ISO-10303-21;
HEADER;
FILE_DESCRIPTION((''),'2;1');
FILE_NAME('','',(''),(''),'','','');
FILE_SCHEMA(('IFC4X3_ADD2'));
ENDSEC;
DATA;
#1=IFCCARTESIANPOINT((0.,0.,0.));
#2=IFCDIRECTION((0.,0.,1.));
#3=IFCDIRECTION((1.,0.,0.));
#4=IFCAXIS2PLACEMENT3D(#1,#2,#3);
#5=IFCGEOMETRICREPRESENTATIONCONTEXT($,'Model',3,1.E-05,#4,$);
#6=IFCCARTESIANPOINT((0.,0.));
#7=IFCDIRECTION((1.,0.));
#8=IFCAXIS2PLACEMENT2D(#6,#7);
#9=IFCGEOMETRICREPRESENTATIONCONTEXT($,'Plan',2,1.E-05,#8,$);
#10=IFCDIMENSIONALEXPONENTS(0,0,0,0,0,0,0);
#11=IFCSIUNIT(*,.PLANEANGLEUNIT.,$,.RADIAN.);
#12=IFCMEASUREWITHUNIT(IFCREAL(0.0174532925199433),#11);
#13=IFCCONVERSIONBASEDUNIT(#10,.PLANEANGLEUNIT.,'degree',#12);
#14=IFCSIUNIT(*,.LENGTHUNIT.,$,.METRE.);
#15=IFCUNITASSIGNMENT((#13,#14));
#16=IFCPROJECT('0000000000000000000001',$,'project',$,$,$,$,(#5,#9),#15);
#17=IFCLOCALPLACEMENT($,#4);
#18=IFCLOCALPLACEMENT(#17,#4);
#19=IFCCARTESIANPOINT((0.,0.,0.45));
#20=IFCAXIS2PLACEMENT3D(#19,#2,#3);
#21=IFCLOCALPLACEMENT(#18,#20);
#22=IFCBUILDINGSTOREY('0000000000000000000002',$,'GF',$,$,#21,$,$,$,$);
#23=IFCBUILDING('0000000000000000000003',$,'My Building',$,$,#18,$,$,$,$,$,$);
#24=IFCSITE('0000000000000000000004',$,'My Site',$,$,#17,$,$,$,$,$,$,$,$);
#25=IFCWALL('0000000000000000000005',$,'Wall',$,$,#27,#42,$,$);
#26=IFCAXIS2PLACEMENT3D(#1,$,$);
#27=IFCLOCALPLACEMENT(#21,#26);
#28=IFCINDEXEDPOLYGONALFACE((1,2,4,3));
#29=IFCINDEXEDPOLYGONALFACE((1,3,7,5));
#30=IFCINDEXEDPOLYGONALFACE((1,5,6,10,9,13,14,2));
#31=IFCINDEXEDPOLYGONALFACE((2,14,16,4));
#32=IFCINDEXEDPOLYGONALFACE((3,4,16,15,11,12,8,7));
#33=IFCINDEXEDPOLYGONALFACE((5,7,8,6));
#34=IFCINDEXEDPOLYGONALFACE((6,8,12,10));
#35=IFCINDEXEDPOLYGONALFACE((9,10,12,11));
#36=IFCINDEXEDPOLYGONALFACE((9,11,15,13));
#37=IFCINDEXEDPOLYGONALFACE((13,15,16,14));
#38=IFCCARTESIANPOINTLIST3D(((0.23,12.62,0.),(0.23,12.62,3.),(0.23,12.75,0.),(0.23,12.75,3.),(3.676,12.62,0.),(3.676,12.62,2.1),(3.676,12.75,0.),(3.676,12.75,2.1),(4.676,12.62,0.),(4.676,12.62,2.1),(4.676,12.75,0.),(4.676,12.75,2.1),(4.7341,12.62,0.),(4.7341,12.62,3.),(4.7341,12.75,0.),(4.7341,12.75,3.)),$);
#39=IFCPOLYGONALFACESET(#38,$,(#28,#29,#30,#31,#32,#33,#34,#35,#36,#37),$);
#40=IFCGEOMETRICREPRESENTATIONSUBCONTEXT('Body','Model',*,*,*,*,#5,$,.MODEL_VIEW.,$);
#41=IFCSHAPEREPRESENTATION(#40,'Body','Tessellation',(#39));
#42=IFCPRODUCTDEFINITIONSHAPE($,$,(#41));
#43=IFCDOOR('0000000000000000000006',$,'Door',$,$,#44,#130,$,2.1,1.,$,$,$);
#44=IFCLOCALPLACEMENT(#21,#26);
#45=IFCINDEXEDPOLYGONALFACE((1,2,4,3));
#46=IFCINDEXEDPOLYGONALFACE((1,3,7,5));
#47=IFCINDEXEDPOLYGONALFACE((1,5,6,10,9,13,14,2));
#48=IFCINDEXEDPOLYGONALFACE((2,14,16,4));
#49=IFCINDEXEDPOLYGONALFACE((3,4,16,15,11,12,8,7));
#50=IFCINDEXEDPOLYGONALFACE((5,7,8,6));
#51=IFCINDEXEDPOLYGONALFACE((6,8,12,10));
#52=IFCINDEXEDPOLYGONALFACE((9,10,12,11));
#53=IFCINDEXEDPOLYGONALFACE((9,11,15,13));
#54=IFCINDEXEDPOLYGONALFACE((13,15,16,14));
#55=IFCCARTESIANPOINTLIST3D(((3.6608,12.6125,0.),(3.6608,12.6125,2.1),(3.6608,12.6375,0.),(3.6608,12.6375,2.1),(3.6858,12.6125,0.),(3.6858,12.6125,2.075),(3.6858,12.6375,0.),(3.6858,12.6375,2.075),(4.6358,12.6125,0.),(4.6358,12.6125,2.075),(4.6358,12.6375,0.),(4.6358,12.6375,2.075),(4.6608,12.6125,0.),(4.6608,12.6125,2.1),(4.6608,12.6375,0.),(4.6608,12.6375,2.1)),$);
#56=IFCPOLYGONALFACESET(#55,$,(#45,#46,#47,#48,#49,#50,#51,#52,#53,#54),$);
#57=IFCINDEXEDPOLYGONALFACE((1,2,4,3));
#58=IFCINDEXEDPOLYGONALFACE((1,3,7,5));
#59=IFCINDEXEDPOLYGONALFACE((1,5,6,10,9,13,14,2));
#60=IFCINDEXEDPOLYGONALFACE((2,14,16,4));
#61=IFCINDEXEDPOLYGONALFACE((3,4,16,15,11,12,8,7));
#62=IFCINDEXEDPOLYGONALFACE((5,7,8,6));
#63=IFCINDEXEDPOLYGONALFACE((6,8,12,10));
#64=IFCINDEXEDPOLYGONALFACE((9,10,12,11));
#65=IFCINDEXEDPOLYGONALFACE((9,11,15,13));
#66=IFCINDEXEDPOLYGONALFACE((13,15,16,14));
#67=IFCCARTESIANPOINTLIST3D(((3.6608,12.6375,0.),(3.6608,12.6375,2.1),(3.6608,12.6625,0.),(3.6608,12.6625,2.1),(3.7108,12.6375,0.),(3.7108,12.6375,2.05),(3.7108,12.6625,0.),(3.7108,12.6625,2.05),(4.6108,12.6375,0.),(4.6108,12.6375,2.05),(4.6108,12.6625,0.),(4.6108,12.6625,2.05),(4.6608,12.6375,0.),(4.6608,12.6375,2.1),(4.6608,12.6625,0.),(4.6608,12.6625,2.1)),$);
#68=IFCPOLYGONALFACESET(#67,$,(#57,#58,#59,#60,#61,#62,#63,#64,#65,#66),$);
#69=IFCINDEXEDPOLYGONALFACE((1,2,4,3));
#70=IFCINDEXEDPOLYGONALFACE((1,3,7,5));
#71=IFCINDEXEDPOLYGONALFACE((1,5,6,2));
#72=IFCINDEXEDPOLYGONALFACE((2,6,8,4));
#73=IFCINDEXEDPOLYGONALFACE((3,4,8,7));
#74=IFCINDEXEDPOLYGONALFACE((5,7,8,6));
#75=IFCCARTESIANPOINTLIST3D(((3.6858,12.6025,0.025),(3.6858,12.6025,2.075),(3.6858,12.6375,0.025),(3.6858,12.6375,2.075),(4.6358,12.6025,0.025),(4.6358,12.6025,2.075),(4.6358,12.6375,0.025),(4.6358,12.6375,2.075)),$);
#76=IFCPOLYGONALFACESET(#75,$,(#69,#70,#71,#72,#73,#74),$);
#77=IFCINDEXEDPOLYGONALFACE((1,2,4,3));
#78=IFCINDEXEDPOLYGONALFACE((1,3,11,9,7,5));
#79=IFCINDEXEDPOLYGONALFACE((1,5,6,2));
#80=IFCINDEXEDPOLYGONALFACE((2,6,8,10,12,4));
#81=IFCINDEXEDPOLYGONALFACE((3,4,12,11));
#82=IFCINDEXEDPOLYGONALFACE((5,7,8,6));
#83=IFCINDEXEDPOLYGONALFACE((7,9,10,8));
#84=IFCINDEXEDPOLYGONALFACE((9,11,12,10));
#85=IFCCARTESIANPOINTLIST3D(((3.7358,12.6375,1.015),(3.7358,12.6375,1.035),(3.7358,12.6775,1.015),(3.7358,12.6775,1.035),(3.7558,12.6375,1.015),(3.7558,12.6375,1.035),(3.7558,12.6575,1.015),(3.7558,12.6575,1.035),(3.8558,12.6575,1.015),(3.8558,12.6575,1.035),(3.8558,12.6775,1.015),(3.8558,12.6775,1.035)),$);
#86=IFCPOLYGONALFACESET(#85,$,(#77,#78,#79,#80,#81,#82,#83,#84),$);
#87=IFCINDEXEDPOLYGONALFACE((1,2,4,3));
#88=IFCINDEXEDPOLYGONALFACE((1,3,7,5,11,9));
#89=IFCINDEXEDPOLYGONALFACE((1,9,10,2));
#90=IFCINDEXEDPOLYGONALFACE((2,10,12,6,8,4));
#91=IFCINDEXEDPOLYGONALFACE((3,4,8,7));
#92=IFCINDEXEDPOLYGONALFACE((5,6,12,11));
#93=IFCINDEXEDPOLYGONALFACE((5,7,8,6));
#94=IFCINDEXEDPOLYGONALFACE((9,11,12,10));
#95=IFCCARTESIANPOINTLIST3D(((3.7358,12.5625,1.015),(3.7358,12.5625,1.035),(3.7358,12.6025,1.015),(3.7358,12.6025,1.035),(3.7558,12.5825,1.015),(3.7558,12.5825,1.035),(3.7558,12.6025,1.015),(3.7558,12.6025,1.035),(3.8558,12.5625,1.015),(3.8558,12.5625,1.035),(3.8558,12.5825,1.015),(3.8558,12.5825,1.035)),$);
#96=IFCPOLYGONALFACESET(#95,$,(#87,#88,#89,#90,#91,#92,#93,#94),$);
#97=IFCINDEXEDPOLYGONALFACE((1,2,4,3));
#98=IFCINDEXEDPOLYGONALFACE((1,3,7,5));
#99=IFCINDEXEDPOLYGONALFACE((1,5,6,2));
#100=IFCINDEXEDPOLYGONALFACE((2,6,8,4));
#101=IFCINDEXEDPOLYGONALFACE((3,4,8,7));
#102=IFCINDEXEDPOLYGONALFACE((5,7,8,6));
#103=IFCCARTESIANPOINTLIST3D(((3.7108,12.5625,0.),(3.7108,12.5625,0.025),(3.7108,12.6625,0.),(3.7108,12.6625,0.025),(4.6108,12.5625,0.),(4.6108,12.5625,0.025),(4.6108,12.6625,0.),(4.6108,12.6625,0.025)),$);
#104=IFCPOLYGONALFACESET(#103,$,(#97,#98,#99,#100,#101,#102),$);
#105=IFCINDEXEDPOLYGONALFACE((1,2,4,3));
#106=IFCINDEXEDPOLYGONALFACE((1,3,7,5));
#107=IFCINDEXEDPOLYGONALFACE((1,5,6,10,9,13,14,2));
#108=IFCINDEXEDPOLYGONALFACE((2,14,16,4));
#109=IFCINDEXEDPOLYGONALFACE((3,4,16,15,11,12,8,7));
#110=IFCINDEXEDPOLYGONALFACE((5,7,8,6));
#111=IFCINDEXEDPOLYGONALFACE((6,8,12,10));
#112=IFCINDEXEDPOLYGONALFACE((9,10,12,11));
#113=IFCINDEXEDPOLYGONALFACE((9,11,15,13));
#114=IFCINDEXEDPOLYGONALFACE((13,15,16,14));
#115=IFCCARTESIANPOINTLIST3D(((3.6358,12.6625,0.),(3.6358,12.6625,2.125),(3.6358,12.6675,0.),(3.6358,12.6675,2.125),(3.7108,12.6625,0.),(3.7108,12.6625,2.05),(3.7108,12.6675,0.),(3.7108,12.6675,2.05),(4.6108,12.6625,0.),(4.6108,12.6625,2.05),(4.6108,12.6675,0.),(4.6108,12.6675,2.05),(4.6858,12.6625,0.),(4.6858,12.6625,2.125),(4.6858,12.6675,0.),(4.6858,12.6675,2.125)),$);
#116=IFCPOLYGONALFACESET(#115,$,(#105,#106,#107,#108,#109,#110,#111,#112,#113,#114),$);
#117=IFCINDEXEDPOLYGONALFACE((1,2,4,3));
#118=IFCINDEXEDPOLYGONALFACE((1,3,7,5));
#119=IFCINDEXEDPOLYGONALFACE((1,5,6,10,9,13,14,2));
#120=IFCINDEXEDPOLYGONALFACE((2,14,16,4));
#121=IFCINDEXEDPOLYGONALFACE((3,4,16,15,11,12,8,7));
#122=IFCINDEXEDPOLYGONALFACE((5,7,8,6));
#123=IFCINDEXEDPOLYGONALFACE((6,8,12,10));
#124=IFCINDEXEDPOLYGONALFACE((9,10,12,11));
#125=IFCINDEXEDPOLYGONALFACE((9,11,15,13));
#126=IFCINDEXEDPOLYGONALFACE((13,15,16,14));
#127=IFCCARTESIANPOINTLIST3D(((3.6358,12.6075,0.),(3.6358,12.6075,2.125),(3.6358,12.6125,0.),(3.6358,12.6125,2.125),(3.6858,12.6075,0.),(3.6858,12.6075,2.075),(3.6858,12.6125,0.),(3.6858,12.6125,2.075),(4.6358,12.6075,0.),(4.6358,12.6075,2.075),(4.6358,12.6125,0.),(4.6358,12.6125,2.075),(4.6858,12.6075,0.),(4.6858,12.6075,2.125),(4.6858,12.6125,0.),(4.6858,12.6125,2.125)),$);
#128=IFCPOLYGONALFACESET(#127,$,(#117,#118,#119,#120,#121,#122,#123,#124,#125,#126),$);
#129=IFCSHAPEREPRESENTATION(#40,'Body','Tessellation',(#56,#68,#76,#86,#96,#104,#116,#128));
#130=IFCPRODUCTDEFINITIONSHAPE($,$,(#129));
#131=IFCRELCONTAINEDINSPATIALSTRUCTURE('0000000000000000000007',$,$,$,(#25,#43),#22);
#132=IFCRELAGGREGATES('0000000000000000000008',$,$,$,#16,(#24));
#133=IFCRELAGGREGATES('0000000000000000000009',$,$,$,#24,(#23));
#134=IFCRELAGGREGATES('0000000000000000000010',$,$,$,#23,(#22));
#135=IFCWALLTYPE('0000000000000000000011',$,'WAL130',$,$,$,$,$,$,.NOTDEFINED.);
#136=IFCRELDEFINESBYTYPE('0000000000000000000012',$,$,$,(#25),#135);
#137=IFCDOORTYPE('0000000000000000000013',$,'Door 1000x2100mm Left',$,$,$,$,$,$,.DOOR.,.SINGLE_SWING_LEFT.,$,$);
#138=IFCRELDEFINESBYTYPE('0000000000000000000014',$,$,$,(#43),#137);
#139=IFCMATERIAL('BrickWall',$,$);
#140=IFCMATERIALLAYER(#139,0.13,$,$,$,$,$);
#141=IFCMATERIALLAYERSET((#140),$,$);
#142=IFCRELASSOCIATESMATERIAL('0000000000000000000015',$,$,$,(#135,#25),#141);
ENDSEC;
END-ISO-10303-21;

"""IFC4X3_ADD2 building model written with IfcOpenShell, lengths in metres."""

from ifc_helpers import new_model, entity, si_unit, converted_unit, frame, origin_with_axes, origin_2d_with_axis, place, context, subcontext, project, spatial, line, indexed_curve, outline, extrude, shape, source, transform, mapped, material, layer, layer_set, layer_usage, type_object, type_shapes, element, fill, save


model = new_model("IFC4X3_ADD2")

# Units and contexts
model_context = context("Model", 3, precision=1e-05, world=origin_with_axes())
plan_context = context("Plan", 2, precision=1e-05, world=origin_2d_with_axis())
body_context_1 = subcontext(model_context, "Body", "Model", "MODEL_VIEW")
body_context_2 = subcontext(plan_context, "Body", "Plan", "PLAN_VIEW")
ifc_project = project(units=[converted_unit("PLANEANGLEUNIT", "degree", entity("IfcReal", 0.0174532925199433), si_unit("PLANEANGLEUNIT", "RADIAN"), dimensions=[0, 0, 0, 0, 0, 0, 0]), si_unit("LENGTHUNIT", "METRE")], contexts=[model_context, plan_context])

# Site, building, storey
site_placement = place(None, origin_with_axes())
site = spatial("IfcSite", under=ifc_project, at=site_placement, Name="My Site")
building_placement = place(site_placement, origin_with_axes())
building = spatial("IfcBuilding", under=site, at=building_placement, Name="My Building")
storey_placement = place(building_placement, frame((0.0, 0.0, 0.45), z_axis=(0.0, 0.0, 1.0), x_axis=(1.0, 0.0, 0.0)))
storey = spatial("IfcBuildingStorey", under=building, at=storey_placement, Name="GF")

# Shared definitions
ifc_material_1 = material(Name="BrickWall")

# Wall, opening, door
ifc_layer_1 = layer(ifc_material_1, 0.13)
ifc_layer_set_1 = layer_set([ifc_layer_1])
ifc_layer_usage_1 = layer_usage(ifc_layer_set_1, "AXIS2", "POSITIVE", 0.0)
wall_type_1 = type_object("IfcWallType", Name="WAL130", PredefinedType="NOTDEFINED", material=ifc_layer_set_1)
wall_1_placement = place(storey_placement, frame((0.23, 12.62, 0.0), z_axis=(0.0, 0.0, 1.0), x_axis=(1.0, 0.0, 0.0)))
wall_1 = element("IfcWall", 1, at=wall_1_placement, inside=storey, type_object=wall_type_1, material=ifc_layer_usage_1, Name="Wall", context=body_context_1, shape_type="SweptSolid", body=[
    extrude(outline(indexed_curve([(0.0, 0.0), (0.0, 0.13), (4.5041, 0.13), (4.5041, 0.0), (0.0, 0.0)], self_intersect=False)), origin_with_axes(), (0.0, 0.0, 1.0), 3.0),
])
shared_shape_1 = source(origin_with_axes(), body_context_1, "Body", "SweptSolid", [
    extrude(outline(indexed_curve([(0.0, 0.0), (1.0, 0.0), (1.0, 2.1), (0.0, 2.1)], segments=[line(1, 2, 3, 4, 1)])), frame((0.0, -0.6, 0.0), z_axis=(0.0, -1.0, 0.0), x_axis=(1.0, 0.0, 0.0)), (0.0, 0.0, -1.0), 1.2),
])
opening_1_placement = place(wall_1_placement, frame((4.446, 0.0875, 0.0), z_axis=(0.0, 0.0, 1.0), x_axis=(-1.0, 0.0, 0.0)))
opening_1 = element("IfcOpeningElement", 2, at=opening_1_placement, cuts=wall_1, PredefinedType="OPENING", context=body_context_1, shape_type="MappedRepresentation", body=[
    mapped(shared_shape_1, transform((0.0, 0.0, 0.0), x_axis=(1.0, 0.0, 0.0), y_axis=(0.0, 1.0, 0.0), z_axis=(0.0, 0.0, 1.0), scale=1.0)),
])
door_type_1 = type_object("IfcDoorType", Name="Door 1000x2100mm Left", OperationType="SINGLE_SWING_LEFT", PredefinedType="DOOR")
shared_shape_2 = source(origin_with_axes(), body_context_1, "Body", "SweptSolid", [
    extrude(outline(indexed_curve([(0.0, 0.0), (0.0, 2.1), (1.0, 2.1), (1.0, 0.0), (0.975, 0.0), (0.975, 2.075), (0.025, 2.075), (0.025, 0.0)], segments=[line(1, 2, 3, 4, 5, 6, 7, 8, 1)])), frame((0.0, 0.025, 0.0), z_axis=(0.0, -1.0, 0.0), x_axis=(1.0, 0.0, 0.0)), (0.0, 0.0, -1.0), 0.025),
    extrude(outline(indexed_curve([(0.0, 0.0), (0.0, 2.1), (1.0, 2.1), (1.0, 0.0), (0.95, 0.0), (0.95, 2.05), (0.05, 2.05), (0.05, 0.0)], segments=[line(1, 2, 3, 4, 5, 6, 7, 8, 1)])), frame((0.0, 0.0, 0.0), z_axis=(0.0, -1.0, 0.0), x_axis=(1.0, 0.0, 0.0)), (0.0, 0.0, -1.0), 0.025),
    extrude(outline(indexed_curve([(0.0, 0.0), (0.95, 0.0), (0.95, 0.035), (0.0, 0.035)], segments=[line(1, 2, 3, 4, 1)])), frame((0.025, 0.025, 0.025), z_axis=(0.0, 0.0, 1.0), x_axis=(1.0, 0.0, 0.0)), (0.0, 0.0, 1.0), 2.05),
    extrude(outline(indexed_curve([(0.0, 0.0), (0.0, -0.04), (-0.12, -0.04), (-0.12, -0.02), (-0.02, -0.02), (-0.02, 0.0)], segments=[line(1, 2, 3, 4, 5, 6, 1)])), frame((0.925, 0.025, 1.015), z_axis=(0.0, 0.0, 1.0), x_axis=(1.0, 0.0, 0.0)), (0.0, 0.0, 1.0), 0.02),
    extrude(outline(indexed_curve([(0.0, 0.0), (0.0, 0.04), (-0.12, 0.04), (-0.12, 0.02), (-0.02, 0.02), (-0.02, 0.0)], segments=[line(1, 2, 3, 4, 5, 6, 1)])), frame((0.925, 0.06, 1.015), z_axis=(0.0, 0.0, 1.0), x_axis=(1.0, 0.0, 0.0)), (0.0, 0.0, 1.0), 0.02),
    extrude(outline(indexed_curve([(0.0, 0.0), (0.9, 0.0), (0.9, 0.1), (0.0, 0.1)], segments=[line(1, 2, 3, 4, 1)])), frame((0.05, 0.0, 0.0), z_axis=(0.0, 0.0, 1.0), x_axis=(1.0, 0.0, 0.0)), (0.0, 0.0, 1.0), 0.025),
    extrude(outline(indexed_curve([(0.0, 0.0), (0.0, 2.125), (1.05, 2.125), (1.05, 0.0), (0.975, 0.0), (0.975, 2.05), (0.075, 2.05), (0.075, 0.0)], segments=[line(1, 2, 3, 4, 5, 6, 7, 8, 1)])), frame((-0.025, -0.005, 0.0), z_axis=(0.0, -1.0, 0.0), x_axis=(1.0, 0.0, 0.0)), (0.0, 0.0, -1.0), 0.005),
    extrude(outline(indexed_curve([(0.0, 0.0), (0.0, 2.125), (1.05, 2.125), (1.05, 0.0), (1.0, 0.0), (1.0, 2.075), (0.05, 2.075), (0.05, 0.0)], segments=[line(1, 2, 3, 4, 5, 6, 7, 8, 1)])), frame((-0.025, 0.05, 0.0), z_axis=(0.0, -1.0, 0.0), x_axis=(1.0, 0.0, 0.0)), (0.0, 0.0, -1.0), 0.005),
])
shared_shape_3 = source(origin_with_axes(), body_context_2, "Body", "Curve2D", [
    entity("IfcIndexedPolyCurve", entity("IfcCartesianPointList2D", [[0.0, 0.0], [0.0, 0.05], [0.025, 0.05], [0.025, 0.025], [0.05, 0.025], [0.05, 0.0]]), [entity("IfcLineIndex", [1, 2, 3, 4, 5, 6, 1])]),
    entity("IfcIndexedPolyCurve", entity("IfcCartesianPointList2D", [[1.0, 0.0], [1.0, 0.05], [0.975, 0.05], [0.975, 0.025], [0.95, 0.025], [0.95, 0.0]]), [entity("IfcLineIndex", [1, 2, 3, 4, 5, 6, 1])]),
    entity("IfcTrimmedCurve", entity("IfcEllipse", entity("IfcAxis2Placement2D", entity("IfcCartesianPoint", [0.06, 0.05]), entity("IfcDirection", [1.0, 0.0])), 0.915, 0.95), [entity("IfcCartesianPoint", [0.975, 0.05])], [entity("IfcCartesianPoint", [0.06, 1.0])], True, "CARTESIAN"),
    entity("IfcIndexedPolyCurve", entity("IfcCartesianPointList2D", [[0.025, 0.05], [0.06, 0.05], [0.06, 1.0], [0.025, 1.0]]), [entity("IfcLineIndex", [1, 2, 3, 4, 1])]),
])
type_shapes(door_type_1, [shared_shape_2, shared_shape_3])
door_1_placement = place(opening_1_placement, frame((0.0152, 0.045, 0.0), z_axis=(0.0, 0.0, 1.0), x_axis=(1.0, 0.0, 0.0)))
door_1 = element("IfcDoor", 3, at=door_1_placement, inside=storey, type_object=door_type_1, Name="Door", OverallHeight=2.1, OverallWidth=1.0, shapes=[
    shape(body_context_1, "Body", "MappedRepresentation", [mapped(shared_shape_2, transform((0.0, 0.0, 0.0), x_axis=(1.0, 0.0, 0.0), y_axis=(0.0, 1.0, 0.0), z_axis=(0.0, 0.0, 1.0), scale=1.0))]),
    shape(body_context_2, "Body", "MappedRepresentation", [mapped(shared_shape_3, transform((0.0, 0.0, 0.0), x_axis=(1.0, 0.0, 0.0), y_axis=(0.0, 1.0, 0.0), z_axis=(0.0, 0.0, 1.0), scale=1.0))]),
])
fill(opening_1, door_1)

save(model, "model.ifc")
